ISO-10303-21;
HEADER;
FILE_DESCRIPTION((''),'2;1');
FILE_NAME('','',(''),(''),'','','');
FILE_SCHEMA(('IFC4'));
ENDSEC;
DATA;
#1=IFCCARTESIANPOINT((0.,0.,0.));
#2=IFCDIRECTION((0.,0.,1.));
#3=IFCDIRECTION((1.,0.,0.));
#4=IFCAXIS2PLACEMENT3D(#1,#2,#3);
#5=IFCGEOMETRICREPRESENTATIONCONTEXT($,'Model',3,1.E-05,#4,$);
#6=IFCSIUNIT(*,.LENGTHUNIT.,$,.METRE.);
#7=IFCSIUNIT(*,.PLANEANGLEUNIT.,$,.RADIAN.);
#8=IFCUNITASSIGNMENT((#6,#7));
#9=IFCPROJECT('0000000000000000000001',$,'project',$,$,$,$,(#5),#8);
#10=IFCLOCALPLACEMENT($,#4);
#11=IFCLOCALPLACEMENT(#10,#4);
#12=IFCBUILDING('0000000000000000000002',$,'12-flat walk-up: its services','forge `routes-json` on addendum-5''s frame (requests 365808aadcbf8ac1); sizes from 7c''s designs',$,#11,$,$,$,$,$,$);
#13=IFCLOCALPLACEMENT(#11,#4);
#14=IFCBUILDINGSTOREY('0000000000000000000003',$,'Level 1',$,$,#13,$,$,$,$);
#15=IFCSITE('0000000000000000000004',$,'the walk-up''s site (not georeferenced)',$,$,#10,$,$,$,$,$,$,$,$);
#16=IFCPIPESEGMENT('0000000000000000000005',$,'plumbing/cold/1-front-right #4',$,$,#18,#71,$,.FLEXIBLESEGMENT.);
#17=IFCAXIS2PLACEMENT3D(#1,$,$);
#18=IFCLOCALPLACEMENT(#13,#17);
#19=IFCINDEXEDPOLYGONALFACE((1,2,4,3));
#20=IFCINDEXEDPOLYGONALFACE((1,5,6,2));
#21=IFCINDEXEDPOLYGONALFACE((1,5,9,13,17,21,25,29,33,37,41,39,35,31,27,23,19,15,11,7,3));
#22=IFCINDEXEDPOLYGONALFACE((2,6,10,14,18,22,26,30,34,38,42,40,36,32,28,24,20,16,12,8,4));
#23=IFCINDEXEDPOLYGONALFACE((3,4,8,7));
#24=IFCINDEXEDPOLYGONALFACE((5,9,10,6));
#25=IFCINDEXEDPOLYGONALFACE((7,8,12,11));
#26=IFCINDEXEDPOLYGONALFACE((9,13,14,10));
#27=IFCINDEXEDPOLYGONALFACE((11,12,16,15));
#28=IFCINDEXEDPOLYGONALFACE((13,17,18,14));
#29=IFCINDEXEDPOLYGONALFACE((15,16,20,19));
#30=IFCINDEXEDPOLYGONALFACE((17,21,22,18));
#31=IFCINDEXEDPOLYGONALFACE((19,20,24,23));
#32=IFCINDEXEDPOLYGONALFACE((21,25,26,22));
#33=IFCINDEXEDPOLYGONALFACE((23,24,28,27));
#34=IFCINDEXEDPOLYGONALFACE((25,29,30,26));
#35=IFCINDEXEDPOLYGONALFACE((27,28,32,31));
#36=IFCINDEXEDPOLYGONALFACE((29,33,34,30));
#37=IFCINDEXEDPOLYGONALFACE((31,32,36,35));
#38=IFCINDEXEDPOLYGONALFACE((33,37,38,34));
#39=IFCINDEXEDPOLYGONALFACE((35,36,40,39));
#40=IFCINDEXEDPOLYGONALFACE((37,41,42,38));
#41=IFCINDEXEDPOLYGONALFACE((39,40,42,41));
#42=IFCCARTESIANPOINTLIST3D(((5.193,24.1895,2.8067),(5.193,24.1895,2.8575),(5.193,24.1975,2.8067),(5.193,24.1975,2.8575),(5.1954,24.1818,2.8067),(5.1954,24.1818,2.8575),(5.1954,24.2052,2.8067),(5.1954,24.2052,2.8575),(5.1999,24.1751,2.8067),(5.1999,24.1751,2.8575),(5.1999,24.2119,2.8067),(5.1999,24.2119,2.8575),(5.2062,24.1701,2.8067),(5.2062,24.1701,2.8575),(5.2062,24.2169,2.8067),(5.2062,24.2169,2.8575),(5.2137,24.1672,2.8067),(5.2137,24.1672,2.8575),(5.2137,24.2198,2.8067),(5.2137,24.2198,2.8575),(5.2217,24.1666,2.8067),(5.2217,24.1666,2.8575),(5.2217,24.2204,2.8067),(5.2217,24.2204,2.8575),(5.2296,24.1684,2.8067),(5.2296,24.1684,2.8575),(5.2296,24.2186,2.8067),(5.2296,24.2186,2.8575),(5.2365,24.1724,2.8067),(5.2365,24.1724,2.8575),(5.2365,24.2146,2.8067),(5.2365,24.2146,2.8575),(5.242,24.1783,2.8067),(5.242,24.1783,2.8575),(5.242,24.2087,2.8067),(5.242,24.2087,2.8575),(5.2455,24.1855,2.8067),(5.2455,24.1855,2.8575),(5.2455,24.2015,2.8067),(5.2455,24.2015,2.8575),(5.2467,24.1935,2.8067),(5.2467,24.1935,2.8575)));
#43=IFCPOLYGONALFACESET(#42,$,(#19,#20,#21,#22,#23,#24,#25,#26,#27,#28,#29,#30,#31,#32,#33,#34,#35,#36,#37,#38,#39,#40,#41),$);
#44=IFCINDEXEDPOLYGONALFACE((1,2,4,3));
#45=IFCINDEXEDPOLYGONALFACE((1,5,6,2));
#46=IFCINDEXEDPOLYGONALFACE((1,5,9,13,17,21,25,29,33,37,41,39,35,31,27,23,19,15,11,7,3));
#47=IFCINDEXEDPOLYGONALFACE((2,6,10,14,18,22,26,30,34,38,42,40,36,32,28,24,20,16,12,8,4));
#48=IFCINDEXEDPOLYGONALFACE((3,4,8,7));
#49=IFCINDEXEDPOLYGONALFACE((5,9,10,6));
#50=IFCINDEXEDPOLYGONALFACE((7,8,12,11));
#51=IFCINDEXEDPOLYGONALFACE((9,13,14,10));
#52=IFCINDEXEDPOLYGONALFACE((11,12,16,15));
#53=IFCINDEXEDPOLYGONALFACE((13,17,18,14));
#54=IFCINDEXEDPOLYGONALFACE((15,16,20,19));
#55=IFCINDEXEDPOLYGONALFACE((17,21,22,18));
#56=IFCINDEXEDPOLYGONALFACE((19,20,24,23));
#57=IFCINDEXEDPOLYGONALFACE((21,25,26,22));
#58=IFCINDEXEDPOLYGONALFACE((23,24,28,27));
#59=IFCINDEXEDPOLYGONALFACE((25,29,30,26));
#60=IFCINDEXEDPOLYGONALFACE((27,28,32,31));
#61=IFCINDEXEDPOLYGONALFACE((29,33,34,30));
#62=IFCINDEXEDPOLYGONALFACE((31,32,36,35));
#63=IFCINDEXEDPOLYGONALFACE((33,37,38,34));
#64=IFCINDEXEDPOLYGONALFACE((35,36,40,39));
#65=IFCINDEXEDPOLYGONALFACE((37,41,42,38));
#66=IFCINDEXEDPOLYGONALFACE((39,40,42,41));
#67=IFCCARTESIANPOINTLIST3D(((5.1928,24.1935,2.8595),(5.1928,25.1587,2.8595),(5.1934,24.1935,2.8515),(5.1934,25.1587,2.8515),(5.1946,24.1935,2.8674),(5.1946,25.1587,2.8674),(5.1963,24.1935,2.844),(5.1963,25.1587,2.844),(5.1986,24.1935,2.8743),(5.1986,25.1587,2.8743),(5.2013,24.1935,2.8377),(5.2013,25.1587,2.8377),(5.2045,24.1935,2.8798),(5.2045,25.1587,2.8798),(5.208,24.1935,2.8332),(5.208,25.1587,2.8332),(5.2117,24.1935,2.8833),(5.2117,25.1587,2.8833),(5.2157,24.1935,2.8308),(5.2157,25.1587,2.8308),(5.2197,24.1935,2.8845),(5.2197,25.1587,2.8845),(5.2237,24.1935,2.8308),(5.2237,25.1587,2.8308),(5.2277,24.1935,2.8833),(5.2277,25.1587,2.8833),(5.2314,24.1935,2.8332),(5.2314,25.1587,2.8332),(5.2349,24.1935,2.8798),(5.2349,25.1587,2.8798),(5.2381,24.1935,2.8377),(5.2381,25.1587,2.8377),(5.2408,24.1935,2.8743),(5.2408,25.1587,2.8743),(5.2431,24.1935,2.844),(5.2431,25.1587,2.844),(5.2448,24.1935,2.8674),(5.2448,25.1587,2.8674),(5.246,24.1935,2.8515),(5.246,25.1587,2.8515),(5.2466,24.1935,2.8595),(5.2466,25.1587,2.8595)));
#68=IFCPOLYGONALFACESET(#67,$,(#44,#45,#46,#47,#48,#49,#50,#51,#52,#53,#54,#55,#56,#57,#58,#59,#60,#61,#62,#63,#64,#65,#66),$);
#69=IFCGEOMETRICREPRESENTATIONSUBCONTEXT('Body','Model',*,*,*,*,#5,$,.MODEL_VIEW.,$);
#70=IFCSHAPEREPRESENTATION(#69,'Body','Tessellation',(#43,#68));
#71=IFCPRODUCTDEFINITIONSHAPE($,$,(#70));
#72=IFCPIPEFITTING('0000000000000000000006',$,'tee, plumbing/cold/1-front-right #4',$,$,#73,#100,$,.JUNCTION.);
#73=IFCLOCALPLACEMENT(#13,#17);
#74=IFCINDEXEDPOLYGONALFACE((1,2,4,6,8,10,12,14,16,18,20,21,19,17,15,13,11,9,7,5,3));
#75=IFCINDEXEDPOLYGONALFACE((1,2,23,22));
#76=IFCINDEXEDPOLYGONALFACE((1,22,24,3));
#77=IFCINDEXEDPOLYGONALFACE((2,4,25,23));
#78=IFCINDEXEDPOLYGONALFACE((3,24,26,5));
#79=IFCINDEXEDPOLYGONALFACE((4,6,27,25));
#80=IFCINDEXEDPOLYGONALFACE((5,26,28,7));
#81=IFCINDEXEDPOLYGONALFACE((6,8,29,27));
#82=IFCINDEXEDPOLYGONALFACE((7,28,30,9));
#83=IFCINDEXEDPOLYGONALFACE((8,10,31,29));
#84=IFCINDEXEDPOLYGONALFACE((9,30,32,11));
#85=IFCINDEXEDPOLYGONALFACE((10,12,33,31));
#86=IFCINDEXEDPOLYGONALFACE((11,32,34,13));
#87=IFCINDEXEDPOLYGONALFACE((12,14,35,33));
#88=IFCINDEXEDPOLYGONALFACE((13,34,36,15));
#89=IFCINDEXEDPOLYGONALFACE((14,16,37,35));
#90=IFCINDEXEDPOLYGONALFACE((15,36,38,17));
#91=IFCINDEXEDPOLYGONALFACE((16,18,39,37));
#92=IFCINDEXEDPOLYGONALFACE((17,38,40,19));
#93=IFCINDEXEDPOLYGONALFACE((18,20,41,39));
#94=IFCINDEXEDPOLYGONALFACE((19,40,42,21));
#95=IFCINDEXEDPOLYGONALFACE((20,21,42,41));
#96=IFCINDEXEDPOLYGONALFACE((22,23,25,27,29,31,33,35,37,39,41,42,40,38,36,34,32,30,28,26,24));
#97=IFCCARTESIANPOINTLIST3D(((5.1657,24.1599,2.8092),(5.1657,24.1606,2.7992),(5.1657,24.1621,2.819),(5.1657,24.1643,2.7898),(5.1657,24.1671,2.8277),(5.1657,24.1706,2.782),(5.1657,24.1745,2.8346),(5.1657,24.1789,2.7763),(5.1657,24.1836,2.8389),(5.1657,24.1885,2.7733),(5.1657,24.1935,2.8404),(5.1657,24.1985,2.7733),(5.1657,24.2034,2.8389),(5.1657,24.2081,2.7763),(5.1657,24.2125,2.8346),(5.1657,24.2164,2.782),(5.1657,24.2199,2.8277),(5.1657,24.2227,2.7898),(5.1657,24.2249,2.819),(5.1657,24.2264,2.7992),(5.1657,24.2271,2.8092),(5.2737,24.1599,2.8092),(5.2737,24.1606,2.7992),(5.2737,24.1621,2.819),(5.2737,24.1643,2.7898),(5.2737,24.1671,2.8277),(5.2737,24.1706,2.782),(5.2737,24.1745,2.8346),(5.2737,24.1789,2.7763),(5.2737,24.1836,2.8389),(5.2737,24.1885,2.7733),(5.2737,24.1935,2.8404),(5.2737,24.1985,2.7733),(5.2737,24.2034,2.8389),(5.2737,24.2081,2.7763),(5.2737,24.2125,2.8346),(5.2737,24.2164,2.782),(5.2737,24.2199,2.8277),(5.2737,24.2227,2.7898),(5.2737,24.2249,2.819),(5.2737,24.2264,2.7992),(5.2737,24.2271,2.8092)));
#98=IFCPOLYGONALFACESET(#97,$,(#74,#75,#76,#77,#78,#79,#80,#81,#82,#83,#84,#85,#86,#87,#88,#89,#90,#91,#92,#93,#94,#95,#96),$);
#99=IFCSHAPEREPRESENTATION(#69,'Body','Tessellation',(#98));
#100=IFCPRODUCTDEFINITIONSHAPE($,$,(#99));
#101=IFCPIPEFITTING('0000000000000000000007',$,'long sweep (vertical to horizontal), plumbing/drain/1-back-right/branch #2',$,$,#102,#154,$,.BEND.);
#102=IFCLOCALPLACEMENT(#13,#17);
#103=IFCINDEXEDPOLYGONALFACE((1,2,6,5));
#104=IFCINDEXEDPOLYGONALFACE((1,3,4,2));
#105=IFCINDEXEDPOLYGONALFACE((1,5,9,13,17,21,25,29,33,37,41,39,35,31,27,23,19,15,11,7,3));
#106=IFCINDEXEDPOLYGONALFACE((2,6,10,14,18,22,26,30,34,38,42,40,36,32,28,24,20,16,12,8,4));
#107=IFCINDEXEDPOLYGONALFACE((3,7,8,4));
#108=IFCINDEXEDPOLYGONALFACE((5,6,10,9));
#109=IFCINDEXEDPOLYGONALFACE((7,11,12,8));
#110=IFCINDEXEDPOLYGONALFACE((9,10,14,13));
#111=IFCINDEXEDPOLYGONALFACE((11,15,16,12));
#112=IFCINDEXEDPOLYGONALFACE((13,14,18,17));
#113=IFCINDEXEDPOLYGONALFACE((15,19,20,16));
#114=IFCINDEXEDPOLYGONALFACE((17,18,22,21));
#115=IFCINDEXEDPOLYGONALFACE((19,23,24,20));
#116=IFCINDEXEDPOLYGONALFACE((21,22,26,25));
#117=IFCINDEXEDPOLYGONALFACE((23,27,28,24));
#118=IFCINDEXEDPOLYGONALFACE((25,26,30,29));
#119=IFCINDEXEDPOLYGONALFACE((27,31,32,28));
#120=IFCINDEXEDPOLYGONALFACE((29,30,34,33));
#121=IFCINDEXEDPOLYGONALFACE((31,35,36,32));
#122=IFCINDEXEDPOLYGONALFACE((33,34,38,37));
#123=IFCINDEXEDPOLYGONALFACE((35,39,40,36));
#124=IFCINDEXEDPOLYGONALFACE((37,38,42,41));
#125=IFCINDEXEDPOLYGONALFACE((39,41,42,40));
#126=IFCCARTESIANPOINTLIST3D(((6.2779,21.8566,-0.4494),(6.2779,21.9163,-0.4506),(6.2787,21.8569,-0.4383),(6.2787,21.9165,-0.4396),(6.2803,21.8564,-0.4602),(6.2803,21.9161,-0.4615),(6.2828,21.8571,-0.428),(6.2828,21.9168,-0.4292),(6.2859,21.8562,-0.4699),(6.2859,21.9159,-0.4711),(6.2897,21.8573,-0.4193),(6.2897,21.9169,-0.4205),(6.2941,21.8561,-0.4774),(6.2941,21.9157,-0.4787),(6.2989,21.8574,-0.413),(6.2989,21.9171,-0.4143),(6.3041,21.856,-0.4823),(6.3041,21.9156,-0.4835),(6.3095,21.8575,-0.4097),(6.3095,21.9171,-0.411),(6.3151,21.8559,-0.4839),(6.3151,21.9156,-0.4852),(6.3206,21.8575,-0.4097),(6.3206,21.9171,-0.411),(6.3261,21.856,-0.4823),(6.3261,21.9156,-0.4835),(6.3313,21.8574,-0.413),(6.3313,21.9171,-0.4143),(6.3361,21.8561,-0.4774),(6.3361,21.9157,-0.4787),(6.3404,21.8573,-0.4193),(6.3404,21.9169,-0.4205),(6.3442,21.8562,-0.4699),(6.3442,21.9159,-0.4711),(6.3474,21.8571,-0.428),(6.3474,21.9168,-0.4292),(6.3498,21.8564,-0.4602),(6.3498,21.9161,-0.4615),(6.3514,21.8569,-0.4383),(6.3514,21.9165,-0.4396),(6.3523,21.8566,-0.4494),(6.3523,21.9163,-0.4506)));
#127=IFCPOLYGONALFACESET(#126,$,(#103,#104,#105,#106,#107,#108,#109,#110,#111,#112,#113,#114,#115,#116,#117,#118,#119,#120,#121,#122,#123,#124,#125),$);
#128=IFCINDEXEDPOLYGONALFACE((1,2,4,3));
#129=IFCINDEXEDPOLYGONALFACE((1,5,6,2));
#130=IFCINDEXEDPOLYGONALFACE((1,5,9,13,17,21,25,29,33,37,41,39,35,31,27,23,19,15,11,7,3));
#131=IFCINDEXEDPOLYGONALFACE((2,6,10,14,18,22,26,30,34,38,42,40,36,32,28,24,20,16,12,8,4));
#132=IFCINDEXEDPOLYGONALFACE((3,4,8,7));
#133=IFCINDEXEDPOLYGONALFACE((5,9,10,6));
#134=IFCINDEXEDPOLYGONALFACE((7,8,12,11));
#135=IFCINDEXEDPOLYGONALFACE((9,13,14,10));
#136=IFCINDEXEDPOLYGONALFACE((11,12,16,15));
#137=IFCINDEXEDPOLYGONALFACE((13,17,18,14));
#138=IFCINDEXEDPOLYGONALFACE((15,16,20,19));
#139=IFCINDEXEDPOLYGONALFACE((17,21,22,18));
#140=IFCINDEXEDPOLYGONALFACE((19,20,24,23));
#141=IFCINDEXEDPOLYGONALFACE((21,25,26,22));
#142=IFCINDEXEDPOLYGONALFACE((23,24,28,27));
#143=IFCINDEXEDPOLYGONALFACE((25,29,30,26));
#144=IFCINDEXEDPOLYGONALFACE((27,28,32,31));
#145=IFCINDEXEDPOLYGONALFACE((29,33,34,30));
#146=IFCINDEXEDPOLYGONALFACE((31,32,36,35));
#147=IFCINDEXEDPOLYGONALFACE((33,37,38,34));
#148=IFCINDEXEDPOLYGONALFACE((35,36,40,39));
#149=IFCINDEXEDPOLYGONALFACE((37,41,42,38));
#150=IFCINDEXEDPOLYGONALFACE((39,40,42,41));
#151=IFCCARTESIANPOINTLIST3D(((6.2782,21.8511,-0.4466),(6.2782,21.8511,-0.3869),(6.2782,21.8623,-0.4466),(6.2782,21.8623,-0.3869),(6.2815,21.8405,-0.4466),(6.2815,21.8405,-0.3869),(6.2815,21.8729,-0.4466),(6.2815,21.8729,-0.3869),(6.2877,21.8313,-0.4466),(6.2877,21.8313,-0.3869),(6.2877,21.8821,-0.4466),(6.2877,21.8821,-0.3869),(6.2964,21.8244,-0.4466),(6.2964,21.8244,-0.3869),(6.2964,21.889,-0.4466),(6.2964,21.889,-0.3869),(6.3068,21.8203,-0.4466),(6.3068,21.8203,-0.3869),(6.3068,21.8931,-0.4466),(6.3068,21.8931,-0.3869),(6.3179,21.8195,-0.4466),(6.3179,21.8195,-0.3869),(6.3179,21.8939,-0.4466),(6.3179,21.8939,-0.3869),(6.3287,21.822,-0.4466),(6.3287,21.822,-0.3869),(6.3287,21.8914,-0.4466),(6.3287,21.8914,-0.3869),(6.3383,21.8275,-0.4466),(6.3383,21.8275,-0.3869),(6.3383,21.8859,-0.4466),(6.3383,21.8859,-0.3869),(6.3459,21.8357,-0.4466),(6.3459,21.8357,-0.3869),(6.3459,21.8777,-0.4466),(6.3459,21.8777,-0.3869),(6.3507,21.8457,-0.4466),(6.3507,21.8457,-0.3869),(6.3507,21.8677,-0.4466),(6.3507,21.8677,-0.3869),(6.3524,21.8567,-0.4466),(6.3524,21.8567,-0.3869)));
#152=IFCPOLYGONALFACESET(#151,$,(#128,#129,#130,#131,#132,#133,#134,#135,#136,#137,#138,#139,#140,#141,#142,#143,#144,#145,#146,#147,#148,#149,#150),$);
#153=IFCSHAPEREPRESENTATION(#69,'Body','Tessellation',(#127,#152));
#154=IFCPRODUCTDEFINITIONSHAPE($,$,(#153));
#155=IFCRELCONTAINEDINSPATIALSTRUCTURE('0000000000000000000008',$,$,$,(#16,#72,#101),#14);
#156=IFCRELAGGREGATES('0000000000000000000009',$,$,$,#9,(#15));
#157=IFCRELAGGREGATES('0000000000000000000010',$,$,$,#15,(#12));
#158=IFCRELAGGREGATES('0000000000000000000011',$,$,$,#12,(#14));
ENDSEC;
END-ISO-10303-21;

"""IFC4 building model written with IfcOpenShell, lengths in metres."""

from ifc_helpers import new_model, entity, si_unit, frame, origin_with_axes, place, context, subcontext, project, spatial, element, save


model = new_model("IFC4")

# Units and contexts
model_context = context("Model", 3, precision=1e-05, world=origin_with_axes())
body_context = subcontext(model_context, "Body", "Model", "MODEL_VIEW")
ifc_project = project(units=[si_unit("LENGTHUNIT", "METRE"), si_unit("PLANEANGLEUNIT", "RADIAN")], contexts=[model_context])

# Site, building, storey
site_placement = place(None, origin_with_axes())
site = spatial("IfcSite", under=ifc_project, at=site_placement, Name="the walk-up's site (not georeferenced)")
building_placement = place(site_placement, origin_with_axes())
building = spatial("IfcBuilding", under=site, at=building_placement, Name="12-flat walk-up: its services", Description="forge `routes-json` on addendum-5's frame (requests 365808aadcbf8ac1); sizes from 7c's designs")
storey_placement = place(building_placement, origin_with_axes())
storey = spatial("IfcBuildingStorey", under=building, at=storey_placement, Name="Level 1")

# Pipe segment
pipe_segment_1_placement = place(storey_placement, frame((5.2197, 24.1935, 2.8067), z_axis=(0.0, 0.0, 1.0), x_axis=(1.0, 0.0, 0.0)))
element("IfcPipeSegment", 1, at=pipe_segment_1_placement, inside=storey, Name="plumbing/cold/1-front-right #4", PredefinedType="FLEXIBLESEGMENT", context=body_context, shape_type="AdvancedSweptSolid", body=[
    entity("IfcSweptDiskSolid", entity("IfcPolyline", [entity("IfcCartesianPoint", [0.0, 0.0, 0.0]), entity("IfcCartesianPoint", [0.0, 0.0, 0.0508])]), 0.027),
    entity("IfcSweptDiskSolid", entity("IfcPolyline", [entity("IfcCartesianPoint", [0.0, 0.0, 0.0508]), entity("IfcCartesianPoint", [0.0, 0.9652, 0.0508])]), 0.027),
])

# Pipe fittings
pipe_fitting_1_placement = place(storey_placement, frame((5.1657, 24.1935, 2.8067), z_axis=(0.0, 0.0, 1.0), x_axis=(1.0, 0.0, 0.0)))
element("IfcPipeFitting", 2, at=pipe_fitting_1_placement, inside=storey, Name="tee, plumbing/cold/1-front-right #4", PredefinedType="JUNCTION", context=body_context, shape_type="AdvancedSweptSolid", body=[
    entity("IfcSweptDiskSolid", entity("IfcPolyline", [entity("IfcCartesianPoint", [0.0, 0.0, 0.0]), entity("IfcCartesianPoint", [0.108, 0.0, 0.0])]), 0.0337),
])
pipe_fitting_2_placement = place(storey_placement, frame((6.3151, 21.9164, -0.4479), z_axis=(0.0, 0.0, 1.0), x_axis=(1.0, 0.0, 0.0)))
element("IfcPipeFitting", 3, at=pipe_fitting_2_placement, inside=storey, Name="long sweep (vertical to horizontal), plumbing/drain/1-back-right/branch #2", PredefinedType="BEND", context=body_context, shape_type="AdvancedSweptSolid", body=[
    entity("IfcSweptDiskSolid", entity("IfcPolyline", [entity("IfcCartesianPoint", [0.0, 0.0, 0.0]), entity("IfcCartesianPoint", [0.0, -0.0597, 0.0012])]), 0.0373),
    entity("IfcSweptDiskSolid", entity("IfcPolyline", [entity("IfcCartesianPoint", [0.0, -0.0597, 0.0012]), entity("IfcCartesianPoint", [0.0, -0.0597, 0.0609])]), 0.0373),
])

save(model, "model.ifc")
